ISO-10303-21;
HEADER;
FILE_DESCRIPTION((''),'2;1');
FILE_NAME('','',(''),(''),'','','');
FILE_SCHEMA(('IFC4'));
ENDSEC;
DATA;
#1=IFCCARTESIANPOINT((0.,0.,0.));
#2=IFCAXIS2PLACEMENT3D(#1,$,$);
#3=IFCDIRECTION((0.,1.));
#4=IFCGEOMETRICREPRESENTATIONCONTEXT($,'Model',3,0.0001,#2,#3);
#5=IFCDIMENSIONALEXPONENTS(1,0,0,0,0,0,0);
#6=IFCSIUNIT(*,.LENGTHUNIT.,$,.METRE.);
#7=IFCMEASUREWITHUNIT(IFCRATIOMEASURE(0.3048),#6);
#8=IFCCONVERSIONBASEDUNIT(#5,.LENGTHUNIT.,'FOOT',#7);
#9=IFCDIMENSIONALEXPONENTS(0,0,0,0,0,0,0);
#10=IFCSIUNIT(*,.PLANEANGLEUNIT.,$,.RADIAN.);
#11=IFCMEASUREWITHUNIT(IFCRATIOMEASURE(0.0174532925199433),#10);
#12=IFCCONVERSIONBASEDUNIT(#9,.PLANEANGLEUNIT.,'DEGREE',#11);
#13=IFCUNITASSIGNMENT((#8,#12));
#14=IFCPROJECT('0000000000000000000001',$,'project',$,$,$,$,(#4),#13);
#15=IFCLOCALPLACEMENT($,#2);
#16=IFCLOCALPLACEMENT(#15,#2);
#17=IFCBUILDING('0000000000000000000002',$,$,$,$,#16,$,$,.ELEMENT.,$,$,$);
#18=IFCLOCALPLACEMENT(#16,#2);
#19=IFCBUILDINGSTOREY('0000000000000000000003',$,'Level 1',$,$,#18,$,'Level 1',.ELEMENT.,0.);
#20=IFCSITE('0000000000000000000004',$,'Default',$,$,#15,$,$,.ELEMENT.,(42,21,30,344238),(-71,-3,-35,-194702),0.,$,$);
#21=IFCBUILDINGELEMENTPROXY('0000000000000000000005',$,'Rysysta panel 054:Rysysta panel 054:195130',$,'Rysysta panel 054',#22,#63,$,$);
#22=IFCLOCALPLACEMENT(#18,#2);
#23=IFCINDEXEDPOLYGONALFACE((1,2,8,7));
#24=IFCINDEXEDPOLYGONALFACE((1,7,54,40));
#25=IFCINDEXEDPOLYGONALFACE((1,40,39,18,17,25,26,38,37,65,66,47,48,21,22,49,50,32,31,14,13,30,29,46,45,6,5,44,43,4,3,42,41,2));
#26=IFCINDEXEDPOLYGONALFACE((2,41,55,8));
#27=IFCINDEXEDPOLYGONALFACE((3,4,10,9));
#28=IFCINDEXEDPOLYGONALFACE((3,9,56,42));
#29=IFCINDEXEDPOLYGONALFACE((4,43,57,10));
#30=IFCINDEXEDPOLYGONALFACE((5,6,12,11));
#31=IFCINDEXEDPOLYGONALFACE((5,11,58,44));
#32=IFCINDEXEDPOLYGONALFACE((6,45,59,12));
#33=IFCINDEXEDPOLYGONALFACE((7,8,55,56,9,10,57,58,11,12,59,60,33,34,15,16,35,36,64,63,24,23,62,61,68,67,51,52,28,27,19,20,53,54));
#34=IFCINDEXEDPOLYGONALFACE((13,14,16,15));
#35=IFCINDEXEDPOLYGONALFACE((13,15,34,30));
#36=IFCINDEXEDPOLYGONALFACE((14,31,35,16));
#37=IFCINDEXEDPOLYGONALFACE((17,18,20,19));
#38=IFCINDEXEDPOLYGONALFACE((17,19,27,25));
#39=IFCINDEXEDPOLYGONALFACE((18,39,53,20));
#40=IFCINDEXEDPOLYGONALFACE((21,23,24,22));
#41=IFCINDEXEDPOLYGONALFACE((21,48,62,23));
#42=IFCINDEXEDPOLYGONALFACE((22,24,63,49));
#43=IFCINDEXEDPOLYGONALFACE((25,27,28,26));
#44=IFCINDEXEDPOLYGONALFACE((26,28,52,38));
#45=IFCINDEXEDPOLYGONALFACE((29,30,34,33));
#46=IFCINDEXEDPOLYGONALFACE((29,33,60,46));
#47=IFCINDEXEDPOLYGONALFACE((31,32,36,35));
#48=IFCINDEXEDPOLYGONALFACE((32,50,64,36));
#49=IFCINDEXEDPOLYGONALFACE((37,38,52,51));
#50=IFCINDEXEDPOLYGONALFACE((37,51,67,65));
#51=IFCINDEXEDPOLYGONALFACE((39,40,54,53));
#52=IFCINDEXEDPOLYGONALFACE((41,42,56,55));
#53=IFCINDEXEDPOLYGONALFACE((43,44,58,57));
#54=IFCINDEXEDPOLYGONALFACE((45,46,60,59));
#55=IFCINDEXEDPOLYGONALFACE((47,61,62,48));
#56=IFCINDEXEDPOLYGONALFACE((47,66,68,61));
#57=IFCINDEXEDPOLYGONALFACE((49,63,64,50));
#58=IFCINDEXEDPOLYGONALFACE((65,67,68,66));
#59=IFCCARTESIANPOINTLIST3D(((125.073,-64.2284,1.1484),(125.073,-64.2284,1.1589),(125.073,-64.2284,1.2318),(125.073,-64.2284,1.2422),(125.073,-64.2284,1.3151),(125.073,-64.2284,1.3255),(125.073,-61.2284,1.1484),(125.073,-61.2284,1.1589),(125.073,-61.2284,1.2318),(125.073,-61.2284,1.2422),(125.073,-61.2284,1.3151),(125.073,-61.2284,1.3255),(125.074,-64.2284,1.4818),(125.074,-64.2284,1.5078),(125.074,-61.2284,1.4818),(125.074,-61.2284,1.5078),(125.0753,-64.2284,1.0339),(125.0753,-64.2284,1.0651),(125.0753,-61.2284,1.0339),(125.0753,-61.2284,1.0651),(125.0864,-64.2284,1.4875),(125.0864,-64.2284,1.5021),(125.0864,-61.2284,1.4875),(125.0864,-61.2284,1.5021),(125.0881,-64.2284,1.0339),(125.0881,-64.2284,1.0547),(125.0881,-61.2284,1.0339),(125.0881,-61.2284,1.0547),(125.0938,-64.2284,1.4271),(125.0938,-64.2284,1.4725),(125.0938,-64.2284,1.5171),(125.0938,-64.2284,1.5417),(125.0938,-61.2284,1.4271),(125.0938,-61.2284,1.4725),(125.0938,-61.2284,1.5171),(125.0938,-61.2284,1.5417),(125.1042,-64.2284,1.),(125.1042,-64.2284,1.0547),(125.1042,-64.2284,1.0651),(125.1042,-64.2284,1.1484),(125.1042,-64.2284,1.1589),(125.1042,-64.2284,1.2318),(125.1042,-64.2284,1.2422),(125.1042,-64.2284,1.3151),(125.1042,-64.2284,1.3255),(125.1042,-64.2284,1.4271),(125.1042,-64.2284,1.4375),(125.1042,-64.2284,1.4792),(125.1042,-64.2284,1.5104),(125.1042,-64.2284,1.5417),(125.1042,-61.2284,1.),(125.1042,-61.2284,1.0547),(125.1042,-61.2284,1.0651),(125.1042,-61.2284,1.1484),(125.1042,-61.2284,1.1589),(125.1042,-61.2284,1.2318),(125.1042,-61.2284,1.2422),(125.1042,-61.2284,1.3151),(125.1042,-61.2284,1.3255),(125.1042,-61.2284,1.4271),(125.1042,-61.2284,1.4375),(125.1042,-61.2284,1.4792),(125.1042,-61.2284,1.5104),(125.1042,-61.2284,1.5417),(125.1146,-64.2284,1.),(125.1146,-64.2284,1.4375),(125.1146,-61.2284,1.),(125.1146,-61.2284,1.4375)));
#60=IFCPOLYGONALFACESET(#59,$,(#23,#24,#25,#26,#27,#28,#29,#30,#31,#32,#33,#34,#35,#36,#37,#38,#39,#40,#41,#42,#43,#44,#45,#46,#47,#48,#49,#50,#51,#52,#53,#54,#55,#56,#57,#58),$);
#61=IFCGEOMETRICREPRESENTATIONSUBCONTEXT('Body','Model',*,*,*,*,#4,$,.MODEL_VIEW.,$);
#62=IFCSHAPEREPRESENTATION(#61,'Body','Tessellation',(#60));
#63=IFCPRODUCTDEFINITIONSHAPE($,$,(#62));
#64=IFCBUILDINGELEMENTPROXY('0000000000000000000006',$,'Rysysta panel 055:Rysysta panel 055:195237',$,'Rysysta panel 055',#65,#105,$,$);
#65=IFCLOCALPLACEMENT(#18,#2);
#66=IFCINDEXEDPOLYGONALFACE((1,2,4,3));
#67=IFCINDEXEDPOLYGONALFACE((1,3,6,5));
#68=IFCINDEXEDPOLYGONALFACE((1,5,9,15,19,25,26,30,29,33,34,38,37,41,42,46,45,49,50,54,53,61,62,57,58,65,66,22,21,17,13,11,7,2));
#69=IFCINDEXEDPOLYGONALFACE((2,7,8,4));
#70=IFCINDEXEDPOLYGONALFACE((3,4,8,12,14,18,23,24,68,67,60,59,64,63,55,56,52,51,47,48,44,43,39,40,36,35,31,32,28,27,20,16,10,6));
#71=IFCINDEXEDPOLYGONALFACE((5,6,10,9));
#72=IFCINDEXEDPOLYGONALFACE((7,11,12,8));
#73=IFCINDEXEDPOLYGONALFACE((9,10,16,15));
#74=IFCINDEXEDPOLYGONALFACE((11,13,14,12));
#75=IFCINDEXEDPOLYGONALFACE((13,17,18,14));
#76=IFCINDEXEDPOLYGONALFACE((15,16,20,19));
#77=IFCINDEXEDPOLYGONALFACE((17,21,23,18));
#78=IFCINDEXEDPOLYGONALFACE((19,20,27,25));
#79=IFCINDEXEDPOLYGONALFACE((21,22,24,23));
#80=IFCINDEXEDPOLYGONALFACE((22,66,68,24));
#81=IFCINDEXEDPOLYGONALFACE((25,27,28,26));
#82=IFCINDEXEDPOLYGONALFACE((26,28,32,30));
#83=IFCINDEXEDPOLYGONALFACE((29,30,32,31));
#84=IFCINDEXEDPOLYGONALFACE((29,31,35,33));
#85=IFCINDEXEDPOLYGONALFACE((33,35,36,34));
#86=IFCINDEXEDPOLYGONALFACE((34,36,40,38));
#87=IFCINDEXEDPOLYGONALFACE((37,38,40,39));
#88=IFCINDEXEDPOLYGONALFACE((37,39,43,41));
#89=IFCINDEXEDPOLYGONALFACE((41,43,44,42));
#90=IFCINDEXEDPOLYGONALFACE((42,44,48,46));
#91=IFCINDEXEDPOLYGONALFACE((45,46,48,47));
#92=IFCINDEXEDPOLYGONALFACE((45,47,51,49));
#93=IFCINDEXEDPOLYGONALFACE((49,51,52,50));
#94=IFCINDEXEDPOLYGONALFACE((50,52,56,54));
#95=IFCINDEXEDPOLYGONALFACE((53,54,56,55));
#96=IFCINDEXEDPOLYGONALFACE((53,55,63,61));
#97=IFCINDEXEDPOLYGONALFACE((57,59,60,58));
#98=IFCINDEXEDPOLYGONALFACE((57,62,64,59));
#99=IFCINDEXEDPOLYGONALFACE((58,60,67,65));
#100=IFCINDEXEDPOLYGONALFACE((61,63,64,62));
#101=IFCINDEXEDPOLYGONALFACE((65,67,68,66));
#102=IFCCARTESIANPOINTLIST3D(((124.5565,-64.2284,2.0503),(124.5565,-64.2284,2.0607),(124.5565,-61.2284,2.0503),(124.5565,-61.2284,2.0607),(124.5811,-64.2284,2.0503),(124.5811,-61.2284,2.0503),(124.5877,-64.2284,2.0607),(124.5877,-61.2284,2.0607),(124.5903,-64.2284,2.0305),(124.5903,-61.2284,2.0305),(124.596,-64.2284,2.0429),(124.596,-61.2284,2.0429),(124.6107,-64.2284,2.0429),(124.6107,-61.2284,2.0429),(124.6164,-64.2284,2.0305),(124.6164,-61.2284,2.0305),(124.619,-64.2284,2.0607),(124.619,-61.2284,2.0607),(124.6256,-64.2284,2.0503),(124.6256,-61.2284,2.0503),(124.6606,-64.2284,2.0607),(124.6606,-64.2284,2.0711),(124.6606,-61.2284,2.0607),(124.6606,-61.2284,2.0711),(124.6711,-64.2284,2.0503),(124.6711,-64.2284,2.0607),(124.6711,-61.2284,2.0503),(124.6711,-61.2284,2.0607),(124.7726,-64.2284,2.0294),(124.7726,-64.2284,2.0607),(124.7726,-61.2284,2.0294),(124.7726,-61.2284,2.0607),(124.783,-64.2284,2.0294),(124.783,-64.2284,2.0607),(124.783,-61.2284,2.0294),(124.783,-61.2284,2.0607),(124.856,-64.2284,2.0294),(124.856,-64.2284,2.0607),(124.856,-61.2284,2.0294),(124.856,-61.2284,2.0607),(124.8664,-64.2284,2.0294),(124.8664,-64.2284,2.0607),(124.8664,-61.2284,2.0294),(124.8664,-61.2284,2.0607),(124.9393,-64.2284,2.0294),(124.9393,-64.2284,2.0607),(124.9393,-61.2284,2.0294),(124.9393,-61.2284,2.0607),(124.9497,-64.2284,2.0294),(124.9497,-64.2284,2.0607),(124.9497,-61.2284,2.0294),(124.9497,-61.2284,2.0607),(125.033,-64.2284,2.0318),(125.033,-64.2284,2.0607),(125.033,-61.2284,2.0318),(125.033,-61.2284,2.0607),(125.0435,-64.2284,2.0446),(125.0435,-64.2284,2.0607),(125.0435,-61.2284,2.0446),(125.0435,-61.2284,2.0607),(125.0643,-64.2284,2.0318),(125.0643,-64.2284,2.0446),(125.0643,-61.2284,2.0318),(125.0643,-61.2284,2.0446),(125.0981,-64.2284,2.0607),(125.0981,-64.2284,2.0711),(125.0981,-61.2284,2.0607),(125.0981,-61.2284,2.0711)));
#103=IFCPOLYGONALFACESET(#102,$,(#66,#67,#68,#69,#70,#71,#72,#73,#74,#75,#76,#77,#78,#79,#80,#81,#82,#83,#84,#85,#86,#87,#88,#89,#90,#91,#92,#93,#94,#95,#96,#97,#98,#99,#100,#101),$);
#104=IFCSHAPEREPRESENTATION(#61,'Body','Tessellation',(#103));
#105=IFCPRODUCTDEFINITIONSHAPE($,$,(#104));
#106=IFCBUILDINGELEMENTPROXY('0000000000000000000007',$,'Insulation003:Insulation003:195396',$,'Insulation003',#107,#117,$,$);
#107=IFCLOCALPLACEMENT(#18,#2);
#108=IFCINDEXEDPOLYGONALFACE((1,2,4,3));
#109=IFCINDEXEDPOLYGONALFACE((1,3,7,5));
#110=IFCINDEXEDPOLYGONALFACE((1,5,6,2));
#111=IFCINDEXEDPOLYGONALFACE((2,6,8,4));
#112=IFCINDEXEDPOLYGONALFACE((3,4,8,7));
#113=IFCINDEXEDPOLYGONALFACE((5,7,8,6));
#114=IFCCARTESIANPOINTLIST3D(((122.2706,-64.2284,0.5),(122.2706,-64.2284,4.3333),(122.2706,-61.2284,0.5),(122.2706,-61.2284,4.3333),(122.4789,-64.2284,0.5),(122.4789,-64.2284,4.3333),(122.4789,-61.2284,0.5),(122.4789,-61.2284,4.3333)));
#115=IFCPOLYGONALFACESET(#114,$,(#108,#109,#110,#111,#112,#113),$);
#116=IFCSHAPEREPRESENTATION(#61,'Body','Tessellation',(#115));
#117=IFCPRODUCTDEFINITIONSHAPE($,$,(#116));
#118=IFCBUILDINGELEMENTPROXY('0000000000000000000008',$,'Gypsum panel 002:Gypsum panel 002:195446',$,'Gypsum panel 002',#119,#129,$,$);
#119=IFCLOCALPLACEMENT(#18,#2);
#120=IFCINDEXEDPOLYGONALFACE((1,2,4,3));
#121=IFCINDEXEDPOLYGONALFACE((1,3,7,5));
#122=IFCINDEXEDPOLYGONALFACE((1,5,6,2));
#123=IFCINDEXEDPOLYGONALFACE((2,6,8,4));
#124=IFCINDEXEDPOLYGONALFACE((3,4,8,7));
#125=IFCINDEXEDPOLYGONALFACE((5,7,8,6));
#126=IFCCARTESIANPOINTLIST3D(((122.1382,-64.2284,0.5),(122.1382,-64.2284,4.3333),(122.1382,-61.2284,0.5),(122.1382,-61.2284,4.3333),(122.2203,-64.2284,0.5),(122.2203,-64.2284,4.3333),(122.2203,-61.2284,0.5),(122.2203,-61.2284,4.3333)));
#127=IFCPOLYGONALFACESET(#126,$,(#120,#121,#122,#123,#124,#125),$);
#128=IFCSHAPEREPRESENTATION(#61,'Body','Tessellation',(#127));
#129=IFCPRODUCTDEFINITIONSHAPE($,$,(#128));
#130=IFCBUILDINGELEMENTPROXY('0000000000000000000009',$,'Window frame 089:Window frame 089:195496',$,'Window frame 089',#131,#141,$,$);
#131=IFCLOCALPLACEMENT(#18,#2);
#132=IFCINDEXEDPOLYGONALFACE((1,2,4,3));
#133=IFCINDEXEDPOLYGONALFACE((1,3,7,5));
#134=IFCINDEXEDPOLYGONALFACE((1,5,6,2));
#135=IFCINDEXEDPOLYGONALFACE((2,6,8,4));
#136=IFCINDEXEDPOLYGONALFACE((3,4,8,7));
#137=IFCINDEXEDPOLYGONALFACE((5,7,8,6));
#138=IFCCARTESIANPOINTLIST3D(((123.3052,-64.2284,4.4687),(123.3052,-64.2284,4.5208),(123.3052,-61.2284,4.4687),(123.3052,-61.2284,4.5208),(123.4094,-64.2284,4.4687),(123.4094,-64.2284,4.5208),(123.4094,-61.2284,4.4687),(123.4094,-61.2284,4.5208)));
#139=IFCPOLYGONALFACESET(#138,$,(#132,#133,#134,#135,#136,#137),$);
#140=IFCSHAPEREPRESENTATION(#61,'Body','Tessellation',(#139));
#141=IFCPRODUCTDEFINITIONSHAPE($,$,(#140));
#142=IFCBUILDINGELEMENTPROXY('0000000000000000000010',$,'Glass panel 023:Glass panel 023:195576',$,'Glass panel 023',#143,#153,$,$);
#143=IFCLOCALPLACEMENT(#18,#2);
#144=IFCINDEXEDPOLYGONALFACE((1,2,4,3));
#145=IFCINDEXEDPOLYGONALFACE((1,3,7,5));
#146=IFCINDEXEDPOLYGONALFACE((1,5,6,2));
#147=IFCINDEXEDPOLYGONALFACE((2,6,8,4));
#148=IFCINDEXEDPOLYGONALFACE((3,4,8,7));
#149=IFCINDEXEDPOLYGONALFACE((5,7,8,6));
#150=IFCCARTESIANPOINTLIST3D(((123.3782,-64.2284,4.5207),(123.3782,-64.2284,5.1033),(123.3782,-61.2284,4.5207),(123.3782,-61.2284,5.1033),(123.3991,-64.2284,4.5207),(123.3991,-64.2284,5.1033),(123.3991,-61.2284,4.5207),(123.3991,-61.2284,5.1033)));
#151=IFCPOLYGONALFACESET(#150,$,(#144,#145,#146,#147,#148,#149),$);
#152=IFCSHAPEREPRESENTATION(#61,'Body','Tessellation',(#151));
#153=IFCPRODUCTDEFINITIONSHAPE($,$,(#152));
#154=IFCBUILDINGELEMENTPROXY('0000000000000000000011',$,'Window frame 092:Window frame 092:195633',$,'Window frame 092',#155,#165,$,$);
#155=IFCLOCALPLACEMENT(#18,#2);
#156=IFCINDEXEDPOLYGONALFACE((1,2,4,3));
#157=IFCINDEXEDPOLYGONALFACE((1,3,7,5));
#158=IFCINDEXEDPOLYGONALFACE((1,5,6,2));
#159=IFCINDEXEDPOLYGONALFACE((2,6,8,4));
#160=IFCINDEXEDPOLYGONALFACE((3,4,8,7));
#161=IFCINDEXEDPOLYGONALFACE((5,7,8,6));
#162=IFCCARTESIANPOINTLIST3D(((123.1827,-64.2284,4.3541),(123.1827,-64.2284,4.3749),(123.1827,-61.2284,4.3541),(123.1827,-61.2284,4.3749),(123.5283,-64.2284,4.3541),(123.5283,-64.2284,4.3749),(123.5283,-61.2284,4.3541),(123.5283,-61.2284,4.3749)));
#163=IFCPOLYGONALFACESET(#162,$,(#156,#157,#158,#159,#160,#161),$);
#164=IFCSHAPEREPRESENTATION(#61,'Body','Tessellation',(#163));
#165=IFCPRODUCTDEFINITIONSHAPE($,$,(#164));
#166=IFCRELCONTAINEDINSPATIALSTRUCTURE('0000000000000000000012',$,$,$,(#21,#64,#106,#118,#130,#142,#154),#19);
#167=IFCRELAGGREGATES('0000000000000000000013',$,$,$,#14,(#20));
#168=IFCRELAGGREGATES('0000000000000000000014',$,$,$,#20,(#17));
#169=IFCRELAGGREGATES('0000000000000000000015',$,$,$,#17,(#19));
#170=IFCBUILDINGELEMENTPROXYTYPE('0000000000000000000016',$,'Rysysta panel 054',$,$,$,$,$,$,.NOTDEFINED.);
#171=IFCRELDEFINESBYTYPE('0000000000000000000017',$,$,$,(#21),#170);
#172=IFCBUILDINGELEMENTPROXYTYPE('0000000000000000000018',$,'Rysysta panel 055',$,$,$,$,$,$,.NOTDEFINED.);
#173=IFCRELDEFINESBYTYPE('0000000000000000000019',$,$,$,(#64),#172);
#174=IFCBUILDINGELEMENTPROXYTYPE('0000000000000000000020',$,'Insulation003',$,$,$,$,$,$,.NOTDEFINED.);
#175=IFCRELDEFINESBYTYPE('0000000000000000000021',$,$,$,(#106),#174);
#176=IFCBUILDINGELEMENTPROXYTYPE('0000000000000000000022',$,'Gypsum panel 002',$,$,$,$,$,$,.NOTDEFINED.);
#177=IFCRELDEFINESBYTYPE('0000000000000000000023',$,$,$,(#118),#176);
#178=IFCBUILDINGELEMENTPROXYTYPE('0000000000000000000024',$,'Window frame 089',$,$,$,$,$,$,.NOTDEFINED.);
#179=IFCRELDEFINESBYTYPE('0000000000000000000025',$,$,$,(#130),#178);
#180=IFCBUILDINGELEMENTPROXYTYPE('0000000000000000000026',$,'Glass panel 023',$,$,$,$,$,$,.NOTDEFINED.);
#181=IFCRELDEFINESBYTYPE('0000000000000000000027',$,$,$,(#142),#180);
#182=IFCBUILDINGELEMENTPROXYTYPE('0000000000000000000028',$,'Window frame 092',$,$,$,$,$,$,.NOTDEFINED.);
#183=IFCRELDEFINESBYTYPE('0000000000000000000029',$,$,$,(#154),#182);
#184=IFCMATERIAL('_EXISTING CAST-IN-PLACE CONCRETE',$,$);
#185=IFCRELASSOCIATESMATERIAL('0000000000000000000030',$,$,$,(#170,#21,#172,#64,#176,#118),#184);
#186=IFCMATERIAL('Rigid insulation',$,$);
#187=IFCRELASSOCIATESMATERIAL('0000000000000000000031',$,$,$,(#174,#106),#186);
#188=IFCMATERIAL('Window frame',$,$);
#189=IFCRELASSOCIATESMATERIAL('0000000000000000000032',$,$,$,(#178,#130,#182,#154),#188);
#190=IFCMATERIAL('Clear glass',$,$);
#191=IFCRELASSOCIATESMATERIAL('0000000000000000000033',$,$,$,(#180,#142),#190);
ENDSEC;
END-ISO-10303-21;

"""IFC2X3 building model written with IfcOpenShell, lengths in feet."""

from ifc_helpers import new_model, entity, si_unit, converted_unit, direction, frame, frame_2d, origin, origin_2d_with_axis, place, context, subcontext, project, spatial, polyline, rectangle, outline, extrude, source, transform, mapped, material, type_object, type_shapes, element, save


model = new_model("IFC2X3")

# Units and contexts
model_context = context("Model", 3, precision=0.0001, world=origin(), true_north=direction((0.0, 1.0)))
body_context = subcontext(model_context, "Body", "Model", "MODEL_VIEW")
ifc_project = project(units=[converted_unit("LENGTHUNIT", "FOOT", entity("IfcRatioMeasure", 0.3048), si_unit("LENGTHUNIT", "METRE"), dimensions=[1, 0, 0, 0, 0, 0, 0]), converted_unit("PLANEANGLEUNIT", "DEGREE", entity("IfcRatioMeasure", 0.0174532925199433), si_unit("PLANEANGLEUNIT", "RADIAN"), dimensions=[0, 0, 0, 0, 0, 0, 0])], contexts=[model_context])

# Site, building, storey
site_placement = place(None, origin())
site = spatial("IfcSite", under=ifc_project, at=site_placement, Name="Default", CompositionType="ELEMENT", RefLatitude=(42, 21, 30, 344238), RefLongitude=(-71, -3, -35, -194702), RefElevation=0.0)
building_placement = place(site_placement, origin())
building = spatial("IfcBuilding", under=site, at=building_placement, CompositionType="ELEMENT")
storey_placement = place(building_placement, origin())
storey = spatial("IfcBuildingStorey", under=building, at=storey_placement, Name="Level 1", LongName="Level 1", CompositionType="ELEMENT", Elevation=0.0)

# Building element proxies
ifc_material_1 = material(Name="_EXISTING CAST-IN-PLACE CONCRETE")
building_element_proxy_type_1 = type_object("IfcBuildingElementProxyType", Name="Rysysta panel 054", PredefinedType="NOTDEFINED", material=ifc_material_1)
shared_shape_1 = source(origin(), body_context, "Body", "SweptSolid", [
    extrude(outline(polyline([(-0.1457, -0.022), (0.2918, -0.022), (0.2918, -0.0116), (0.2371, -0.0116), (0.2371, 0.0045), (0.258, 0.0045), (0.258, 0.0173), (0.2267, 0.0173), (0.2267, -0.0116), (0.1434, -0.0116), (0.1434, 0.0196), (0.133, 0.0196), (0.133, -0.0116), (0.06, -0.0116), (0.06, 0.0196), (0.0496, 0.0196), (0.0496, -0.0116), (-0.0233, -0.0116), (-0.0233, 0.0196), (-0.0337, 0.0196), (-0.0337, -0.0116), (-0.1353, -0.0116), (-0.1353, -0.0012), (-0.1807, -0.0012), (-0.1899, 0.0186), (-0.216, 0.0186), (-0.2252, -0.0012), (-0.2498, -0.0012), (-0.2498, -0.0116), (-0.2186, -0.0116), (-0.2103, 0.0062), (-0.1956, 0.0062), (-0.1873, -0.0116), (-0.1457, -0.0116), (-0.1457, -0.022)])), frame((125.0926, -64.2284, 1.2918), z_axis=(0.0, 1.0, 0.0), x_axis=(0.0, 0.0, -1.0)), (0.0, 0.0, 1.0), 3.0),
])
type_shapes(building_element_proxy_type_1, [shared_shape_1])
proxy_1_placement = place(storey_placement, origin())
element("IfcBuildingElementProxy", 1, at=proxy_1_placement, inside=storey, type_object=building_element_proxy_type_1, material=ifc_material_1, Name="Rysysta panel 054:Rysysta panel 054:195130", ObjectType="Rysysta panel 054", context=body_context, shape_type="MappedRepresentation", body=[
    mapped(shared_shape_1, transform((0.0, 0.0, 0.0), scale=1.0)),
])
building_element_proxy_type_2 = type_object("IfcBuildingElementProxyType", Name="Rysysta panel 055", PredefinedType="NOTDEFINED", material=ifc_material_1)
shared_shape_2 = source(origin(), body_context, "Body", "SweptSolid", [
    extrude(outline(polyline([(-0.2918, -0.0116), (-0.2918, -0.022), (0.1457, -0.022), (0.1457, -0.0116), (0.1873, -0.0116), (0.1956, 0.0062), (0.2103, 0.0062), (0.2186, -0.0116), (0.2498, -0.0116), (0.2498, -0.0012), (0.2252, -0.0012), (0.216, 0.0186), (0.1899, 0.0186), (0.1807, -0.0012), (0.1353, -0.0012), (0.1353, -0.0116), (0.0337, -0.0116), (0.0337, 0.0196), (0.0233, 0.0196), (0.0233, -0.0116), (-0.0496, -0.0116), (-0.0496, 0.0196), (-0.06, 0.0196), (-0.06, -0.0116), (-0.133, -0.0116), (-0.133, 0.0196), (-0.1434, 0.0196), (-0.1434, -0.0116), (-0.2267, -0.0116), (-0.2267, 0.0173), (-0.258, 0.0173), (-0.258, 0.0045), (-0.2371, 0.0045), (-0.2371, -0.0116), (-0.2918, -0.0116)])), frame((124.8063, -64.2284, 2.0491), z_axis=(0.0, -1.0, 0.0), x_axis=(-1.0, 0.0, 0.0)), (0.0, 0.0, -1.0), 3.0),
])
type_shapes(building_element_proxy_type_2, [shared_shape_2])
proxy_2_placement = place(storey_placement, origin())
element("IfcBuildingElementProxy", 2, at=proxy_2_placement, inside=storey, type_object=building_element_proxy_type_2, material=ifc_material_1, Name="Rysysta panel 055:Rysysta panel 055:195237", ObjectType="Rysysta panel 055", context=body_context, shape_type="MappedRepresentation", body=[
    mapped(shared_shape_2, transform((0.0, 0.0, 0.0), scale=1.0)),
])
ifc_material_2 = material(Name="Rigid insulation")
building_element_proxy_type_3 = type_object("IfcBuildingElementProxyType", Name="Insulation003", PredefinedType="NOTDEFINED", material=ifc_material_2)
shared_shape_3 = source(origin(), body_context, "Body", "SweptSolid", [
    extrude(rectangle(XDim=3.0, YDim=0.2083, at=frame_2d((0.0, 0.0), x_axis=(1.0, 0.0))), frame((122.3747, -62.7284, 0.5), z_axis=(0.0, 0.0, 1.0), x_axis=(0.0, 1.0, 0.0)), (0.0, 0.0, 1.0), 3.8333),
])
type_shapes(building_element_proxy_type_3, [shared_shape_3])
proxy_3_placement = place(storey_placement, origin())
element("IfcBuildingElementProxy", 3, at=proxy_3_placement, inside=storey, type_object=building_element_proxy_type_3, material=ifc_material_2, Name="Insulation003:Insulation003:195396", ObjectType="Insulation003", context=body_context, shape_type="MappedRepresentation", body=[
    mapped(shared_shape_3, transform((0.0, 0.0, 0.0), scale=1.0)),
])
building_element_proxy_type_4 = type_object("IfcBuildingElementProxyType", Name="Gypsum panel 002", PredefinedType="NOTDEFINED", material=ifc_material_1)
shared_shape_4 = source(origin(), body_context, "Body", "SweptSolid", [
    extrude(rectangle(XDim=3.0, YDim=0.082, at=origin_2d_with_axis()), frame((122.1793, -62.7284, 0.5), z_axis=(0.0, 0.0, 1.0), x_axis=(0.0, 1.0, 0.0)), (0.0, 0.0, 1.0), 3.8333),
])
type_shapes(building_element_proxy_type_4, [shared_shape_4])
proxy_4_placement = place(storey_placement, origin())
element("IfcBuildingElementProxy", 4, at=proxy_4_placement, inside=storey, type_object=building_element_proxy_type_4, material=ifc_material_1, Name="Gypsum panel 002:Gypsum panel 002:195446", ObjectType="Gypsum panel 002", context=body_context, shape_type="MappedRepresentation", body=[
    mapped(shared_shape_4, transform((0.0, 0.0, 0.0), scale=1.0)),
])
ifc_material_3 = material(Name="Window frame")
building_element_proxy_type_5 = type_object("IfcBuildingElementProxyType", Name="Window frame 089", PredefinedType="NOTDEFINED", material=ifc_material_3)
shared_shape_5 = source(origin(), body_context, "Body", "SweptSolid", [
    extrude(rectangle(XDim=3.0, YDim=0.1042, at=frame_2d((0.0, 0.0), x_axis=(1.0, 0.0))), frame((123.3573, -62.7284, 4.4687), z_axis=(0.0, 0.0, 1.0), x_axis=(0.0, 1.0, 0.0)), (0.0, 0.0, 1.0), 0.0521),
])
type_shapes(building_element_proxy_type_5, [shared_shape_5])
proxy_5_placement = place(storey_placement, origin())
element("IfcBuildingElementProxy", 5, at=proxy_5_placement, inside=storey, type_object=building_element_proxy_type_5, material=ifc_material_3, Name="Window frame 089:Window frame 089:195496", ObjectType="Window frame 089", context=body_context, shape_type="MappedRepresentation", body=[
    mapped(shared_shape_5, transform((0.0, 0.0, 0.0), scale=1.0)),
])
ifc_material_4 = material(Name="Clear glass")
building_element_proxy_type_6 = type_object("IfcBuildingElementProxyType", Name="Glass panel 023", PredefinedType="NOTDEFINED", material=ifc_material_4)
shared_shape_6 = source(origin(), body_context, "Body", "SweptSolid", [
    extrude(rectangle(XDim=3.0, YDim=0.0208, at=frame_2d((0.0, 0.0), x_axis=(1.0, 0.0))), frame((123.3887, -62.7284, 4.5207), z_axis=(0.0, 0.0, 1.0), x_axis=(0.0, 1.0, 0.0)), (0.0, 0.0, 1.0), 0.5825),
])
type_shapes(building_element_proxy_type_6, [shared_shape_6])
proxy_6_placement = place(storey_placement, origin())
element("IfcBuildingElementProxy", 6, at=proxy_6_placement, inside=storey, type_object=building_element_proxy_type_6, material=ifc_material_4, Name="Glass panel 023:Glass panel 023:195576", ObjectType="Glass panel 023", context=body_context, shape_type="MappedRepresentation", body=[
    mapped(shared_shape_6, transform((0.0, 0.0, 0.0), scale=1.0)),
])
building_element_proxy_type_7 = type_object("IfcBuildingElementProxyType", Name="Window frame 092", PredefinedType="NOTDEFINED", material=ifc_material_3)
shared_shape_7 = source(origin(), body_context, "Body", "SweptSolid", [
    extrude(rectangle(XDim=3.0, YDim=0.3455, at=frame_2d((0.0, 0.0), x_axis=(1.0, 0.0))), frame((123.3555, -62.7284, 4.3541), z_axis=(0.0, 0.0, 1.0), x_axis=(0.0, 1.0, 0.0)), (0.0, 0.0, 1.0), 0.0208),
])
type_shapes(building_element_proxy_type_7, [shared_shape_7])
proxy_7_placement = place(storey_placement, origin())
element("IfcBuildingElementProxy", 7, at=proxy_7_placement, inside=storey, type_object=building_element_proxy_type_7, material=ifc_material_3, Name="Window frame 092:Window frame 092:195633", ObjectType="Window frame 092", context=body_context, shape_type="MappedRepresentation", body=[
    mapped(shared_shape_7, transform((0.0, 0.0, 0.0), scale=1.0)),
])

save(model, "model.ifc")
